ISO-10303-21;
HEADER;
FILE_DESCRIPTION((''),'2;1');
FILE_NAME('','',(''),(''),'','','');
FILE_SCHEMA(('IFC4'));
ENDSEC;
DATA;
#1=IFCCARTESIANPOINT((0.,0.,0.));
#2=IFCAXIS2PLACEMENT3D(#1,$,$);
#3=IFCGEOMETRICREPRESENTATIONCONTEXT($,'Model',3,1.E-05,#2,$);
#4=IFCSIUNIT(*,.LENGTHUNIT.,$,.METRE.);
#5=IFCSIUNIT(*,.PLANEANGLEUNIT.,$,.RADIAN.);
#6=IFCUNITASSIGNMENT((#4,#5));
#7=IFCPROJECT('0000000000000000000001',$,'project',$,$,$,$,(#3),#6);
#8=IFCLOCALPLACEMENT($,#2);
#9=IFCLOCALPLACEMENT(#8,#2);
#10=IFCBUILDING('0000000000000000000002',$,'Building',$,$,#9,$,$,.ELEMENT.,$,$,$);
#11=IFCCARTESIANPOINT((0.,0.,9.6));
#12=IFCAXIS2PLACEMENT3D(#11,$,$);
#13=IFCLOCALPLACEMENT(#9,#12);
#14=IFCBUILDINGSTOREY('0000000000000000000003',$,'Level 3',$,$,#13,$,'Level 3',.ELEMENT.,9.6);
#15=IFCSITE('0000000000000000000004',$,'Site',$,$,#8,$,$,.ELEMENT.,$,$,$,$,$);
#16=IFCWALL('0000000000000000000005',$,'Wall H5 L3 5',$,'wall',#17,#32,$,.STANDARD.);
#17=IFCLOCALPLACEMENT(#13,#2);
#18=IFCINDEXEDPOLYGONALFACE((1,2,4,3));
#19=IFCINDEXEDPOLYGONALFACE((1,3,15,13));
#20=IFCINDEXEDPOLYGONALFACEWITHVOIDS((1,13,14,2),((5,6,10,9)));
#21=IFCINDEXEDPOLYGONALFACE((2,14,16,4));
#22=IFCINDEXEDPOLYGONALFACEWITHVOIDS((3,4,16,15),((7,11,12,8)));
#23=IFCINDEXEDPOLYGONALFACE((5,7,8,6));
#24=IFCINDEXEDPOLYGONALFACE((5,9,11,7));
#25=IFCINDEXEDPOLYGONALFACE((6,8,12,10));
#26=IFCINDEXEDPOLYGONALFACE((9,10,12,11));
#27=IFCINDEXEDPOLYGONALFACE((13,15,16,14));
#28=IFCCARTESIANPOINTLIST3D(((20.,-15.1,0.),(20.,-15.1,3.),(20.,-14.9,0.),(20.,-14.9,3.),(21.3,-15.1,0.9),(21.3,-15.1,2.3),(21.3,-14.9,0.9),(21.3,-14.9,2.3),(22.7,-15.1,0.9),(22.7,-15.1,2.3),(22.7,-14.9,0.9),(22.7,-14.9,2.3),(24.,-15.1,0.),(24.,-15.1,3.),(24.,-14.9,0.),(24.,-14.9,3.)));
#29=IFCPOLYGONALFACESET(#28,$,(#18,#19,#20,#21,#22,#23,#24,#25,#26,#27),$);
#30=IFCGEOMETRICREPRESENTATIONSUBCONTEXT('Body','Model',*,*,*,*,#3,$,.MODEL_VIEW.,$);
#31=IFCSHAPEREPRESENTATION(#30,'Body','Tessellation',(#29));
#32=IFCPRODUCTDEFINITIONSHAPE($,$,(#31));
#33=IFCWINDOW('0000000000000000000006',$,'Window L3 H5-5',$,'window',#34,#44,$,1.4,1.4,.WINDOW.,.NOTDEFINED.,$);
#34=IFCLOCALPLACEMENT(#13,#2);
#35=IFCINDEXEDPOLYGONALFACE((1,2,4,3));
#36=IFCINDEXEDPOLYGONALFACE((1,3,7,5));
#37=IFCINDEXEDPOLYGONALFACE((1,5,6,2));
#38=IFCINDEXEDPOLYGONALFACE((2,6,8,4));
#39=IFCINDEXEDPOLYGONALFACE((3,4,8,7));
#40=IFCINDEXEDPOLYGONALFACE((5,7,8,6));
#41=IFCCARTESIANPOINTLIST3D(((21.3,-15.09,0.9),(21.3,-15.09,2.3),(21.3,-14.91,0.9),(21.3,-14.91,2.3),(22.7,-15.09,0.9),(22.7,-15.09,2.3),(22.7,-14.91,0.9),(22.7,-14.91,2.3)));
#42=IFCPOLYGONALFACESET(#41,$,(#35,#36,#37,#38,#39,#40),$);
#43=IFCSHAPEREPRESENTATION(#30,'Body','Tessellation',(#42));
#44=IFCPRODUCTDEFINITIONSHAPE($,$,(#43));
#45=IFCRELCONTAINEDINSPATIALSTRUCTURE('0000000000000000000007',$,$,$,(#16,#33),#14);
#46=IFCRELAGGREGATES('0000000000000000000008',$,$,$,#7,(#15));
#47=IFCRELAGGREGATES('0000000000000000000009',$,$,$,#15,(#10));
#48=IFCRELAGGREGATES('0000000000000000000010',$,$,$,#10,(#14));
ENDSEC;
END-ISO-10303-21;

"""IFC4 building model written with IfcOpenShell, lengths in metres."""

from ifc_helpers import new_model, si_unit, frame, frame_2d, origin, origin_2d, place, context, subcontext, project, spatial, rectangle, extrude, element, fill, save


model = new_model("IFC4")

# Units and contexts
model_context = context("Model", 3, precision=1e-05, world=origin())
body_context = subcontext(model_context, "Body", "Model", "MODEL_VIEW")
ifc_project = project(units=[si_unit("LENGTHUNIT", "METRE"), si_unit("PLANEANGLEUNIT", "RADIAN")], contexts=[model_context])

# Site, building, storey
site_placement = place(None, origin())
site = spatial("IfcSite", under=ifc_project, at=site_placement, Name="Site", CompositionType="ELEMENT")
building_placement = place(site_placement, origin())
building = spatial("IfcBuilding", under=site, at=building_placement, Name="Building", CompositionType="ELEMENT")
storey_placement = place(building_placement, frame((0.0, 0.0, 9.6)))
storey = spatial("IfcBuildingStorey", under=building, at=storey_placement, Name="Level 3", LongName="Level 3", CompositionType="ELEMENT", Elevation=9.6)

# Wall, opening, window
wall_1_placement = place(storey_placement, frame((20.0, -15.0, 0.0), z_axis=(0.0, 0.0, 1.0), x_axis=(1.0, 0.0, 0.0)))
wall_1 = element("IfcWall", 1, at=wall_1_placement, inside=storey, Name="Wall H5 L3 5", ObjectType="wall", PredefinedType="STANDARD", context=body_context, shape_type="SweptSolid", body=[
    extrude(rectangle(XDim=4.0, YDim=0.2, at=frame_2d((2.0, 0.0))), origin(), (0.0, 0.0, 1.0), 3.0),
])
opening_1_placement = place(storey_placement, frame((22.0, -15.0, 0.9), z_axis=(0.0, 0.0, 1.0), x_axis=(1.0, 0.0, 0.0)))
opening_1 = element("IfcOpeningElement", 2, at=opening_1_placement, cuts=wall_1, ObjectType="Opening", PredefinedType="OPENING", context=body_context, shape_type="SweptSolid", body=[
    extrude(rectangle(XDim=1.4, YDim=0.22, at=origin_2d()), origin(), (0.0, 0.0, 1.0), 1.4),
])
window_1_placement = place(storey_placement, frame((22.0, -15.0, 0.9), z_axis=(0.0, 0.0, 1.0), x_axis=(1.0, 0.0, 0.0)))
window_1 = element("IfcWindow", 3, at=window_1_placement, inside=storey, Name="Window L3 H5-5", ObjectType="window", OverallHeight=1.4, OverallWidth=1.4, PartitioningType="NOTDEFINED", PredefinedType="WINDOW", context=body_context, shape_type="SweptSolid", body=[
    extrude(rectangle(XDim=1.4, YDim=0.18, at=origin_2d()), origin(), (0.0, 0.0, 1.0), 1.4),
])
fill(opening_1, window_1)

save(model, "model.ifc")
